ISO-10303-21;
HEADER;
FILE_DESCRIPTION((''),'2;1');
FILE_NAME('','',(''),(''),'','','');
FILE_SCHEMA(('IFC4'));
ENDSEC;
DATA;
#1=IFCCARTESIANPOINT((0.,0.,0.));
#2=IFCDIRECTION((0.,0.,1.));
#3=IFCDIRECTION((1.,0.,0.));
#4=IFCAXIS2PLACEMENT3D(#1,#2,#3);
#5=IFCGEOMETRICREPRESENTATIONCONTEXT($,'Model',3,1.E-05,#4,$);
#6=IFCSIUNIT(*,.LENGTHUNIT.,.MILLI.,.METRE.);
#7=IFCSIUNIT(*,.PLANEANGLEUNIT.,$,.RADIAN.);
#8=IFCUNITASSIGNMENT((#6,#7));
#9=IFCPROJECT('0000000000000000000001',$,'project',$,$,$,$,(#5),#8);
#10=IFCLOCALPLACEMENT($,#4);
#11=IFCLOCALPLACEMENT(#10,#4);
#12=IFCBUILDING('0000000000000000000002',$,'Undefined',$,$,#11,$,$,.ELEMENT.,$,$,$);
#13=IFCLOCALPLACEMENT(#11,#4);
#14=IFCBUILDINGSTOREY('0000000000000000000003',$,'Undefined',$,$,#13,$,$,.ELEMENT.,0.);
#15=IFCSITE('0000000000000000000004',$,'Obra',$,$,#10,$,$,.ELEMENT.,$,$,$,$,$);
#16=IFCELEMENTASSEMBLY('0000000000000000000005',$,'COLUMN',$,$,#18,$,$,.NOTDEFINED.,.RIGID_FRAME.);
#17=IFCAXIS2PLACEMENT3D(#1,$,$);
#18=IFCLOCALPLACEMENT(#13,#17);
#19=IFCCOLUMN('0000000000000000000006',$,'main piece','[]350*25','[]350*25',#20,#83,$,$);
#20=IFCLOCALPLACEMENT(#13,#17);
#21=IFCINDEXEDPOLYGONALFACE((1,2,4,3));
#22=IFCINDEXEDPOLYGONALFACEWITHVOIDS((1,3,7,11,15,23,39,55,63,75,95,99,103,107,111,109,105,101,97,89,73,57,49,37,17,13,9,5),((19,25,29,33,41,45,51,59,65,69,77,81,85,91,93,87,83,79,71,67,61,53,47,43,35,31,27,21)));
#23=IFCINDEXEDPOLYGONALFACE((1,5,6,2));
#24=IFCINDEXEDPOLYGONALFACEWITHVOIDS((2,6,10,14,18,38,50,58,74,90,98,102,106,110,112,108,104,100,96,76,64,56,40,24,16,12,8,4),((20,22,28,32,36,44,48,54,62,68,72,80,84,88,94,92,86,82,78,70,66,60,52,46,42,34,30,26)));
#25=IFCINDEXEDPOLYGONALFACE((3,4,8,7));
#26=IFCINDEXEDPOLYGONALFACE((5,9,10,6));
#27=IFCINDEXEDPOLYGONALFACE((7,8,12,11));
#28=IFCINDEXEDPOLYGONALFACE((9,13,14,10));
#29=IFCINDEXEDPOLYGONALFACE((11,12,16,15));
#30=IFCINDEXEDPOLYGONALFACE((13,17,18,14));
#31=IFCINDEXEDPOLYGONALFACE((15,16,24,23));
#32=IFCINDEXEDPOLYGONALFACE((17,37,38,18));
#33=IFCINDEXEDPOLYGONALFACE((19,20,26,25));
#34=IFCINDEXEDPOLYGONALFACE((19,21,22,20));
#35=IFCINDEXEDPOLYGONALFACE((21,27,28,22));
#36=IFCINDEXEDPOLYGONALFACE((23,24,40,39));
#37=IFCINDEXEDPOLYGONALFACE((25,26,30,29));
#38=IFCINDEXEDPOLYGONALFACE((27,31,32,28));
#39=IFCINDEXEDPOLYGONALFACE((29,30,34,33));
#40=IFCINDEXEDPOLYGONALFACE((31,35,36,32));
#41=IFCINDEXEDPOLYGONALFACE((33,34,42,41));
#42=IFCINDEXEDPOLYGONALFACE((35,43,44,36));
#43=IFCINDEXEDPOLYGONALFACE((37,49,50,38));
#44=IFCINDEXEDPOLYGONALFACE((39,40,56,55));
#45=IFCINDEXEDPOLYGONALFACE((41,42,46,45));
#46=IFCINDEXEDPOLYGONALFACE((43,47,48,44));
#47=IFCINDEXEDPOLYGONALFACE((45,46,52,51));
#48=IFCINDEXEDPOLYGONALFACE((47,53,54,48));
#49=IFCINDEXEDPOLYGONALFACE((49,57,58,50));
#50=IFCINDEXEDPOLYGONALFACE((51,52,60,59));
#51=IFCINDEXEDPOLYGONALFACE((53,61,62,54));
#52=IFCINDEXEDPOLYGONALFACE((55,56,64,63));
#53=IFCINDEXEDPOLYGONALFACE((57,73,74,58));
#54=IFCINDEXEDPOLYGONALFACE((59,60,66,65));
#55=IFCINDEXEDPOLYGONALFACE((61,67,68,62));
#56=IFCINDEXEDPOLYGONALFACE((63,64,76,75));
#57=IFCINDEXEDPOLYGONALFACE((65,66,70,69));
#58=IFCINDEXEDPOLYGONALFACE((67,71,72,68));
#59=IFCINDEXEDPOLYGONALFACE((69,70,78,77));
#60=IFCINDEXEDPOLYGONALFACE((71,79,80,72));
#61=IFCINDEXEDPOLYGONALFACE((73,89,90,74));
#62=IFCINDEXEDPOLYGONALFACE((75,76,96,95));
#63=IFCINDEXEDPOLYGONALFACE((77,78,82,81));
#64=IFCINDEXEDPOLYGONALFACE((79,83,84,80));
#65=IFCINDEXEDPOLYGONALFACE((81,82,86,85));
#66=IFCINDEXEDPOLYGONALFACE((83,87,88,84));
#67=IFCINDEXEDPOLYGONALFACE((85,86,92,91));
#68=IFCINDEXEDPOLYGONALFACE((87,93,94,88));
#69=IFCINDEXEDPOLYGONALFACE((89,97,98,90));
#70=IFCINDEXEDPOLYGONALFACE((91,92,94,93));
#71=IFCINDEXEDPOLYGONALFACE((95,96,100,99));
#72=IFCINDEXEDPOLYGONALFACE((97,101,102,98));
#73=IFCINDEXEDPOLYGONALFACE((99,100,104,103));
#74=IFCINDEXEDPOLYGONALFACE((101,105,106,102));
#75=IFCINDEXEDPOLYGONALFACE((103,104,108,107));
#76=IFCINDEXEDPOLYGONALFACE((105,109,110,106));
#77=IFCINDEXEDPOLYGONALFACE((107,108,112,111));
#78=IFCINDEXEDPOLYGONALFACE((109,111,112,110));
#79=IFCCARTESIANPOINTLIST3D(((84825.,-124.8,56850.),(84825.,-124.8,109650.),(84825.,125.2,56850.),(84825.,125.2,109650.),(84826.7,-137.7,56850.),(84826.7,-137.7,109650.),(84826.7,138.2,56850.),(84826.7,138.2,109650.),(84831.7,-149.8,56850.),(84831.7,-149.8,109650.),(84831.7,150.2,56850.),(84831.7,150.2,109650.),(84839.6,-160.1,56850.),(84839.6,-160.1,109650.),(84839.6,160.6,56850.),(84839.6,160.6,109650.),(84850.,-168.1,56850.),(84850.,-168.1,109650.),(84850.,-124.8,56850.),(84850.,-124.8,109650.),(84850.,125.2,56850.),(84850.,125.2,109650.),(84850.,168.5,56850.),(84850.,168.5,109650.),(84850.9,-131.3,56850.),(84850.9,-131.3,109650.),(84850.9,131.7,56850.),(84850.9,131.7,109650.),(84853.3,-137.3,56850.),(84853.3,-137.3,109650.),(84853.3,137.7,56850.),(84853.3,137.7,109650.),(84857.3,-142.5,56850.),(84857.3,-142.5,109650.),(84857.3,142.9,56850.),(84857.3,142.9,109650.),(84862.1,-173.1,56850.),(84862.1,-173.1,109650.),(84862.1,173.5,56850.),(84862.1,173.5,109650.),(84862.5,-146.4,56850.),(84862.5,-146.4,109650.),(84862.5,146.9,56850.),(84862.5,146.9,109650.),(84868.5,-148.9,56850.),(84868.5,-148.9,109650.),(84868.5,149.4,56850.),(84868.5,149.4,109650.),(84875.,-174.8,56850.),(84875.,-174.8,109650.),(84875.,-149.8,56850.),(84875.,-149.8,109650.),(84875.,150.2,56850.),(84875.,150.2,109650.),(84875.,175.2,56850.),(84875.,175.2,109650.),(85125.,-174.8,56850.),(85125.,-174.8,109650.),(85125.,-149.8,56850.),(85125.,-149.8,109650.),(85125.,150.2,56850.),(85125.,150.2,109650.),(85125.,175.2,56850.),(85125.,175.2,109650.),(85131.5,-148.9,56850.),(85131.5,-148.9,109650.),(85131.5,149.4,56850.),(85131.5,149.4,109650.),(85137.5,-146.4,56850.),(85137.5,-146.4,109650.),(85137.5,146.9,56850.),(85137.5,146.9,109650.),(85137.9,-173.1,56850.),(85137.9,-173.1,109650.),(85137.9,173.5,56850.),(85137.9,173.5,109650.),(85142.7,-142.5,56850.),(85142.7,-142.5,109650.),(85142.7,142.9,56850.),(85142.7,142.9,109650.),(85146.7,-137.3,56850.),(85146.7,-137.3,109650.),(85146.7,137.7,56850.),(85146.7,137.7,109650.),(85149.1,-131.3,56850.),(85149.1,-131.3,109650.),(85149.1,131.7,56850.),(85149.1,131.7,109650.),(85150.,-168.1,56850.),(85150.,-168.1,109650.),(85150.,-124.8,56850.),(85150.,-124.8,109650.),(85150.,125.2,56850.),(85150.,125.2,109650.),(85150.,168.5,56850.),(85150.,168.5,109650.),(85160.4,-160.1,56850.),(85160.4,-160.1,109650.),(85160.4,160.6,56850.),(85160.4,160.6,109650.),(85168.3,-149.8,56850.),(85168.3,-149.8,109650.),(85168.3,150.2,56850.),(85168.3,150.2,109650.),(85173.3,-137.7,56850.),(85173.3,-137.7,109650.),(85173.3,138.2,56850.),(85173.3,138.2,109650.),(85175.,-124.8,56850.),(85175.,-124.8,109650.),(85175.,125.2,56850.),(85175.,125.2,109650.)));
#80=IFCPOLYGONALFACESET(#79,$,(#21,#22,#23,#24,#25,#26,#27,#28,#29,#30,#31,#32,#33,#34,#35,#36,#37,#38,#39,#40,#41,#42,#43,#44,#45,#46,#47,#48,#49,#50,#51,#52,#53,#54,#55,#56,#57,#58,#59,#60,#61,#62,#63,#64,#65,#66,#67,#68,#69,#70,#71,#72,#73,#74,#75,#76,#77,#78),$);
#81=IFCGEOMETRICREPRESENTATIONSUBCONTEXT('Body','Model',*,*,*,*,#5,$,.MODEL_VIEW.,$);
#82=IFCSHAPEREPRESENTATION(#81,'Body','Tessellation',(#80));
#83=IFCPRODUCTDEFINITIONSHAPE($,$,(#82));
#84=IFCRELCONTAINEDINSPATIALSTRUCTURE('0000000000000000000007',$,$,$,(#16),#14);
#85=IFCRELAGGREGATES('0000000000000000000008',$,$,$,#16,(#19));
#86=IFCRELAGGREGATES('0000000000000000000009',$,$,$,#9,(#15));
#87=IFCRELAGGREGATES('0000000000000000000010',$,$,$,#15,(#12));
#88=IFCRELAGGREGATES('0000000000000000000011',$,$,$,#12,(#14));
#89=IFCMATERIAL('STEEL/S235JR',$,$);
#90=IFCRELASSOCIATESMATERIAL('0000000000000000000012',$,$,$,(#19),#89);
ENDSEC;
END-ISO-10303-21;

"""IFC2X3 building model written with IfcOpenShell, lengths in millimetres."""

from ifc_helpers import new_model, si_unit, frame, origin_with_axes, origin_2d_with_axis, place, context, subcontext, project, spatial, hollow_rectangle, extrude, material, element, aggregate, save


model = new_model("IFC2X3")

# Units and contexts
model_context = context("Model", 3, precision=1e-05, world=origin_with_axes())
body_context = subcontext(model_context, "Body", "Model", "MODEL_VIEW")
ifc_project = project(units=[si_unit("LENGTHUNIT", "METRE", prefix="MILLI"), si_unit("PLANEANGLEUNIT", "RADIAN")], contexts=[model_context])

# Site, building, storey
site_placement = place(None, origin_with_axes())
site = spatial("IfcSite", under=ifc_project, at=site_placement, Name="Obra", CompositionType="ELEMENT")
building_placement = place(site_placement, origin_with_axes())
building = spatial("IfcBuilding", under=site, at=building_placement, Name="Undefined", CompositionType="ELEMENT")
storey_placement = place(building_placement, origin_with_axes())
storey = spatial("IfcBuildingStorey", under=building, at=storey_placement, Name="Undefined", CompositionType="ELEMENT", Elevation=0.0)

# Element assembly, column
assembly_1_placement = place(storey_placement, origin_with_axes())
assembly_1 = element("IfcElementAssembly", 1, at=assembly_1_placement, inside=storey, Name="COLUMN", AssemblyPlace="NOTDEFINED", PredefinedType="RIGID_FRAME")
ifc_material = material(Name="STEEL/S235JR")
column_placement = place(assembly_1_placement, frame((85000.0, 0.2, 56850.0), z_axis=(0.0, 0.0, 1.0), x_axis=(0.0, 1.0, 0.0)))
column = element("IfcColumn", 2, at=column_placement, material=ifc_material, Name="main piece", Description="[]350*25", ObjectType="[]350*25", context=body_context, shape_type="SweptSolid", body=[
    extrude(hollow_rectangle(XDim=350.0, YDim=350.0, WallThickness=25.0, InnerFilletRadius=25.0, OuterFilletRadius=50.0, at=origin_2d_with_axis()), frame((0.0, 0.0, 52800.0), z_axis=(0.0, 0.0, -1.0), x_axis=(0.0, 1.0, 0.0)), (0.0, 0.0, 1.0), 52800.0),
])
aggregate(assembly_1, [column])

save(model, "model.ifc")
